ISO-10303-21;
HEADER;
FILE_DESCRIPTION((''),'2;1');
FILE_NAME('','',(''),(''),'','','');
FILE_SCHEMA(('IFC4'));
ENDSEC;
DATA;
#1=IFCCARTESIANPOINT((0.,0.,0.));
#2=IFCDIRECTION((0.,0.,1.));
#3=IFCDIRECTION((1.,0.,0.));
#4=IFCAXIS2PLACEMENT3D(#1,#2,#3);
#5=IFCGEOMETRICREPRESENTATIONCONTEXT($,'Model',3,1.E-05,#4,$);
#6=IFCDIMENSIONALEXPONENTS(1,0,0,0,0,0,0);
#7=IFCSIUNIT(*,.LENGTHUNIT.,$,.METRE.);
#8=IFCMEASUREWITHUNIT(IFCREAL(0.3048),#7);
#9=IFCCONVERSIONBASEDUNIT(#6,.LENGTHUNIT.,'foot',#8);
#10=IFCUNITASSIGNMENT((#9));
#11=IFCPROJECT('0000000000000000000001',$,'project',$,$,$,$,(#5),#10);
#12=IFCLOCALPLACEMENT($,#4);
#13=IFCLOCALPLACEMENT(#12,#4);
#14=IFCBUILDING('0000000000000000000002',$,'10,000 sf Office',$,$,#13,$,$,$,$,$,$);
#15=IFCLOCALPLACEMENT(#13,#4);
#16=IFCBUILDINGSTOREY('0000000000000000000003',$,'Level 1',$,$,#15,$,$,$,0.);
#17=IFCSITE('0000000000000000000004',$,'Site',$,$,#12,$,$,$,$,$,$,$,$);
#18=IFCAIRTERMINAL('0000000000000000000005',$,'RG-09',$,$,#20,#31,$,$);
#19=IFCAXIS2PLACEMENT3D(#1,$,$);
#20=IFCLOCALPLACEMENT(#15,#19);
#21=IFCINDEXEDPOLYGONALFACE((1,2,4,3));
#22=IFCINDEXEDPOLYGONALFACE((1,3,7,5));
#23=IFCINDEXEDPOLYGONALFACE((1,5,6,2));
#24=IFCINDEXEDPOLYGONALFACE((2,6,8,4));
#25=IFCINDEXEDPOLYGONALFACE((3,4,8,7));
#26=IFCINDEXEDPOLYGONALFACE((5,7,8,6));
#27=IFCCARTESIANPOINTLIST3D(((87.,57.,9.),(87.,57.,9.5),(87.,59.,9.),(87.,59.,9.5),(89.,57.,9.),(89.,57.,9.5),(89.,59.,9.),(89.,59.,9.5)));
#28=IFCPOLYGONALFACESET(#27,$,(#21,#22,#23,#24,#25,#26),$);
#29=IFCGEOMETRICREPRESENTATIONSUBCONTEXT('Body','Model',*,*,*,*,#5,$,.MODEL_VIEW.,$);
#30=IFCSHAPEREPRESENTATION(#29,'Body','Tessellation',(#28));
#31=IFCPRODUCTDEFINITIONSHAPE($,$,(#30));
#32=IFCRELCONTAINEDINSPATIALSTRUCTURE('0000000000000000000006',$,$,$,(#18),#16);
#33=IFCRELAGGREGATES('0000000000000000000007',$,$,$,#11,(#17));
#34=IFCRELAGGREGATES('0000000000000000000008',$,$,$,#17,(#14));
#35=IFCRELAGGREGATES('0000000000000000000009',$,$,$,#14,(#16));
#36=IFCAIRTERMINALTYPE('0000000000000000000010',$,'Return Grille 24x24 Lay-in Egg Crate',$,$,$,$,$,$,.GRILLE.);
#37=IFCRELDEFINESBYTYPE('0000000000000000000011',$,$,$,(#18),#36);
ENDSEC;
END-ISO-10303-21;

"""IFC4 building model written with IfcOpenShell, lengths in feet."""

from ifc_helpers import new_model, entity, si_unit, converted_unit, frame, origin_with_axes, place, context, subcontext, project, spatial, rectangle, extrude, type_object, element, save


model = new_model("IFC4")

# Units and contexts
model_context = context("Model", 3, precision=1e-05, world=origin_with_axes())
body_context = subcontext(model_context, "Body", "Model", "MODEL_VIEW")
ifc_project = project(units=[converted_unit("LENGTHUNIT", "foot", entity("IfcReal", 0.3048), si_unit("LENGTHUNIT", "METRE"), dimensions=[1, 0, 0, 0, 0, 0, 0])], contexts=[model_context])

# Site, building, storey
site_placement = place(None, origin_with_axes())
site = spatial("IfcSite", under=ifc_project, at=site_placement, Name="Site")
building_placement = place(site_placement, origin_with_axes())
building = spatial("IfcBuilding", under=site, at=building_placement, Name="10,000 sf Office")
storey_placement = place(building_placement, origin_with_axes())
storey = spatial("IfcBuildingStorey", under=building, at=storey_placement, Name="Level 1", Elevation=0.0)

# Air terminal
air_terminal_type_1 = type_object("IfcAirTerminalType", Name="Return Grille 24x24 Lay-in Egg Crate", PredefinedType="GRILLE")
air_terminal_placement = place(storey_placement, frame((88.0, 58.0, 9.0), z_axis=(0.0, 0.0, 1.0), x_axis=(1.0, 0.0, 0.0)))
element("IfcAirTerminal", 1, at=air_terminal_placement, inside=storey, type_object=air_terminal_type_1, Name="RG-09", context=body_context, shape_type="SweptSolid", body=[
    extrude(rectangle(XDim=2.0, YDim=2.0), None, (0.0, 0.0, 1.0), 0.5),
])

save(model, "model.ifc")
